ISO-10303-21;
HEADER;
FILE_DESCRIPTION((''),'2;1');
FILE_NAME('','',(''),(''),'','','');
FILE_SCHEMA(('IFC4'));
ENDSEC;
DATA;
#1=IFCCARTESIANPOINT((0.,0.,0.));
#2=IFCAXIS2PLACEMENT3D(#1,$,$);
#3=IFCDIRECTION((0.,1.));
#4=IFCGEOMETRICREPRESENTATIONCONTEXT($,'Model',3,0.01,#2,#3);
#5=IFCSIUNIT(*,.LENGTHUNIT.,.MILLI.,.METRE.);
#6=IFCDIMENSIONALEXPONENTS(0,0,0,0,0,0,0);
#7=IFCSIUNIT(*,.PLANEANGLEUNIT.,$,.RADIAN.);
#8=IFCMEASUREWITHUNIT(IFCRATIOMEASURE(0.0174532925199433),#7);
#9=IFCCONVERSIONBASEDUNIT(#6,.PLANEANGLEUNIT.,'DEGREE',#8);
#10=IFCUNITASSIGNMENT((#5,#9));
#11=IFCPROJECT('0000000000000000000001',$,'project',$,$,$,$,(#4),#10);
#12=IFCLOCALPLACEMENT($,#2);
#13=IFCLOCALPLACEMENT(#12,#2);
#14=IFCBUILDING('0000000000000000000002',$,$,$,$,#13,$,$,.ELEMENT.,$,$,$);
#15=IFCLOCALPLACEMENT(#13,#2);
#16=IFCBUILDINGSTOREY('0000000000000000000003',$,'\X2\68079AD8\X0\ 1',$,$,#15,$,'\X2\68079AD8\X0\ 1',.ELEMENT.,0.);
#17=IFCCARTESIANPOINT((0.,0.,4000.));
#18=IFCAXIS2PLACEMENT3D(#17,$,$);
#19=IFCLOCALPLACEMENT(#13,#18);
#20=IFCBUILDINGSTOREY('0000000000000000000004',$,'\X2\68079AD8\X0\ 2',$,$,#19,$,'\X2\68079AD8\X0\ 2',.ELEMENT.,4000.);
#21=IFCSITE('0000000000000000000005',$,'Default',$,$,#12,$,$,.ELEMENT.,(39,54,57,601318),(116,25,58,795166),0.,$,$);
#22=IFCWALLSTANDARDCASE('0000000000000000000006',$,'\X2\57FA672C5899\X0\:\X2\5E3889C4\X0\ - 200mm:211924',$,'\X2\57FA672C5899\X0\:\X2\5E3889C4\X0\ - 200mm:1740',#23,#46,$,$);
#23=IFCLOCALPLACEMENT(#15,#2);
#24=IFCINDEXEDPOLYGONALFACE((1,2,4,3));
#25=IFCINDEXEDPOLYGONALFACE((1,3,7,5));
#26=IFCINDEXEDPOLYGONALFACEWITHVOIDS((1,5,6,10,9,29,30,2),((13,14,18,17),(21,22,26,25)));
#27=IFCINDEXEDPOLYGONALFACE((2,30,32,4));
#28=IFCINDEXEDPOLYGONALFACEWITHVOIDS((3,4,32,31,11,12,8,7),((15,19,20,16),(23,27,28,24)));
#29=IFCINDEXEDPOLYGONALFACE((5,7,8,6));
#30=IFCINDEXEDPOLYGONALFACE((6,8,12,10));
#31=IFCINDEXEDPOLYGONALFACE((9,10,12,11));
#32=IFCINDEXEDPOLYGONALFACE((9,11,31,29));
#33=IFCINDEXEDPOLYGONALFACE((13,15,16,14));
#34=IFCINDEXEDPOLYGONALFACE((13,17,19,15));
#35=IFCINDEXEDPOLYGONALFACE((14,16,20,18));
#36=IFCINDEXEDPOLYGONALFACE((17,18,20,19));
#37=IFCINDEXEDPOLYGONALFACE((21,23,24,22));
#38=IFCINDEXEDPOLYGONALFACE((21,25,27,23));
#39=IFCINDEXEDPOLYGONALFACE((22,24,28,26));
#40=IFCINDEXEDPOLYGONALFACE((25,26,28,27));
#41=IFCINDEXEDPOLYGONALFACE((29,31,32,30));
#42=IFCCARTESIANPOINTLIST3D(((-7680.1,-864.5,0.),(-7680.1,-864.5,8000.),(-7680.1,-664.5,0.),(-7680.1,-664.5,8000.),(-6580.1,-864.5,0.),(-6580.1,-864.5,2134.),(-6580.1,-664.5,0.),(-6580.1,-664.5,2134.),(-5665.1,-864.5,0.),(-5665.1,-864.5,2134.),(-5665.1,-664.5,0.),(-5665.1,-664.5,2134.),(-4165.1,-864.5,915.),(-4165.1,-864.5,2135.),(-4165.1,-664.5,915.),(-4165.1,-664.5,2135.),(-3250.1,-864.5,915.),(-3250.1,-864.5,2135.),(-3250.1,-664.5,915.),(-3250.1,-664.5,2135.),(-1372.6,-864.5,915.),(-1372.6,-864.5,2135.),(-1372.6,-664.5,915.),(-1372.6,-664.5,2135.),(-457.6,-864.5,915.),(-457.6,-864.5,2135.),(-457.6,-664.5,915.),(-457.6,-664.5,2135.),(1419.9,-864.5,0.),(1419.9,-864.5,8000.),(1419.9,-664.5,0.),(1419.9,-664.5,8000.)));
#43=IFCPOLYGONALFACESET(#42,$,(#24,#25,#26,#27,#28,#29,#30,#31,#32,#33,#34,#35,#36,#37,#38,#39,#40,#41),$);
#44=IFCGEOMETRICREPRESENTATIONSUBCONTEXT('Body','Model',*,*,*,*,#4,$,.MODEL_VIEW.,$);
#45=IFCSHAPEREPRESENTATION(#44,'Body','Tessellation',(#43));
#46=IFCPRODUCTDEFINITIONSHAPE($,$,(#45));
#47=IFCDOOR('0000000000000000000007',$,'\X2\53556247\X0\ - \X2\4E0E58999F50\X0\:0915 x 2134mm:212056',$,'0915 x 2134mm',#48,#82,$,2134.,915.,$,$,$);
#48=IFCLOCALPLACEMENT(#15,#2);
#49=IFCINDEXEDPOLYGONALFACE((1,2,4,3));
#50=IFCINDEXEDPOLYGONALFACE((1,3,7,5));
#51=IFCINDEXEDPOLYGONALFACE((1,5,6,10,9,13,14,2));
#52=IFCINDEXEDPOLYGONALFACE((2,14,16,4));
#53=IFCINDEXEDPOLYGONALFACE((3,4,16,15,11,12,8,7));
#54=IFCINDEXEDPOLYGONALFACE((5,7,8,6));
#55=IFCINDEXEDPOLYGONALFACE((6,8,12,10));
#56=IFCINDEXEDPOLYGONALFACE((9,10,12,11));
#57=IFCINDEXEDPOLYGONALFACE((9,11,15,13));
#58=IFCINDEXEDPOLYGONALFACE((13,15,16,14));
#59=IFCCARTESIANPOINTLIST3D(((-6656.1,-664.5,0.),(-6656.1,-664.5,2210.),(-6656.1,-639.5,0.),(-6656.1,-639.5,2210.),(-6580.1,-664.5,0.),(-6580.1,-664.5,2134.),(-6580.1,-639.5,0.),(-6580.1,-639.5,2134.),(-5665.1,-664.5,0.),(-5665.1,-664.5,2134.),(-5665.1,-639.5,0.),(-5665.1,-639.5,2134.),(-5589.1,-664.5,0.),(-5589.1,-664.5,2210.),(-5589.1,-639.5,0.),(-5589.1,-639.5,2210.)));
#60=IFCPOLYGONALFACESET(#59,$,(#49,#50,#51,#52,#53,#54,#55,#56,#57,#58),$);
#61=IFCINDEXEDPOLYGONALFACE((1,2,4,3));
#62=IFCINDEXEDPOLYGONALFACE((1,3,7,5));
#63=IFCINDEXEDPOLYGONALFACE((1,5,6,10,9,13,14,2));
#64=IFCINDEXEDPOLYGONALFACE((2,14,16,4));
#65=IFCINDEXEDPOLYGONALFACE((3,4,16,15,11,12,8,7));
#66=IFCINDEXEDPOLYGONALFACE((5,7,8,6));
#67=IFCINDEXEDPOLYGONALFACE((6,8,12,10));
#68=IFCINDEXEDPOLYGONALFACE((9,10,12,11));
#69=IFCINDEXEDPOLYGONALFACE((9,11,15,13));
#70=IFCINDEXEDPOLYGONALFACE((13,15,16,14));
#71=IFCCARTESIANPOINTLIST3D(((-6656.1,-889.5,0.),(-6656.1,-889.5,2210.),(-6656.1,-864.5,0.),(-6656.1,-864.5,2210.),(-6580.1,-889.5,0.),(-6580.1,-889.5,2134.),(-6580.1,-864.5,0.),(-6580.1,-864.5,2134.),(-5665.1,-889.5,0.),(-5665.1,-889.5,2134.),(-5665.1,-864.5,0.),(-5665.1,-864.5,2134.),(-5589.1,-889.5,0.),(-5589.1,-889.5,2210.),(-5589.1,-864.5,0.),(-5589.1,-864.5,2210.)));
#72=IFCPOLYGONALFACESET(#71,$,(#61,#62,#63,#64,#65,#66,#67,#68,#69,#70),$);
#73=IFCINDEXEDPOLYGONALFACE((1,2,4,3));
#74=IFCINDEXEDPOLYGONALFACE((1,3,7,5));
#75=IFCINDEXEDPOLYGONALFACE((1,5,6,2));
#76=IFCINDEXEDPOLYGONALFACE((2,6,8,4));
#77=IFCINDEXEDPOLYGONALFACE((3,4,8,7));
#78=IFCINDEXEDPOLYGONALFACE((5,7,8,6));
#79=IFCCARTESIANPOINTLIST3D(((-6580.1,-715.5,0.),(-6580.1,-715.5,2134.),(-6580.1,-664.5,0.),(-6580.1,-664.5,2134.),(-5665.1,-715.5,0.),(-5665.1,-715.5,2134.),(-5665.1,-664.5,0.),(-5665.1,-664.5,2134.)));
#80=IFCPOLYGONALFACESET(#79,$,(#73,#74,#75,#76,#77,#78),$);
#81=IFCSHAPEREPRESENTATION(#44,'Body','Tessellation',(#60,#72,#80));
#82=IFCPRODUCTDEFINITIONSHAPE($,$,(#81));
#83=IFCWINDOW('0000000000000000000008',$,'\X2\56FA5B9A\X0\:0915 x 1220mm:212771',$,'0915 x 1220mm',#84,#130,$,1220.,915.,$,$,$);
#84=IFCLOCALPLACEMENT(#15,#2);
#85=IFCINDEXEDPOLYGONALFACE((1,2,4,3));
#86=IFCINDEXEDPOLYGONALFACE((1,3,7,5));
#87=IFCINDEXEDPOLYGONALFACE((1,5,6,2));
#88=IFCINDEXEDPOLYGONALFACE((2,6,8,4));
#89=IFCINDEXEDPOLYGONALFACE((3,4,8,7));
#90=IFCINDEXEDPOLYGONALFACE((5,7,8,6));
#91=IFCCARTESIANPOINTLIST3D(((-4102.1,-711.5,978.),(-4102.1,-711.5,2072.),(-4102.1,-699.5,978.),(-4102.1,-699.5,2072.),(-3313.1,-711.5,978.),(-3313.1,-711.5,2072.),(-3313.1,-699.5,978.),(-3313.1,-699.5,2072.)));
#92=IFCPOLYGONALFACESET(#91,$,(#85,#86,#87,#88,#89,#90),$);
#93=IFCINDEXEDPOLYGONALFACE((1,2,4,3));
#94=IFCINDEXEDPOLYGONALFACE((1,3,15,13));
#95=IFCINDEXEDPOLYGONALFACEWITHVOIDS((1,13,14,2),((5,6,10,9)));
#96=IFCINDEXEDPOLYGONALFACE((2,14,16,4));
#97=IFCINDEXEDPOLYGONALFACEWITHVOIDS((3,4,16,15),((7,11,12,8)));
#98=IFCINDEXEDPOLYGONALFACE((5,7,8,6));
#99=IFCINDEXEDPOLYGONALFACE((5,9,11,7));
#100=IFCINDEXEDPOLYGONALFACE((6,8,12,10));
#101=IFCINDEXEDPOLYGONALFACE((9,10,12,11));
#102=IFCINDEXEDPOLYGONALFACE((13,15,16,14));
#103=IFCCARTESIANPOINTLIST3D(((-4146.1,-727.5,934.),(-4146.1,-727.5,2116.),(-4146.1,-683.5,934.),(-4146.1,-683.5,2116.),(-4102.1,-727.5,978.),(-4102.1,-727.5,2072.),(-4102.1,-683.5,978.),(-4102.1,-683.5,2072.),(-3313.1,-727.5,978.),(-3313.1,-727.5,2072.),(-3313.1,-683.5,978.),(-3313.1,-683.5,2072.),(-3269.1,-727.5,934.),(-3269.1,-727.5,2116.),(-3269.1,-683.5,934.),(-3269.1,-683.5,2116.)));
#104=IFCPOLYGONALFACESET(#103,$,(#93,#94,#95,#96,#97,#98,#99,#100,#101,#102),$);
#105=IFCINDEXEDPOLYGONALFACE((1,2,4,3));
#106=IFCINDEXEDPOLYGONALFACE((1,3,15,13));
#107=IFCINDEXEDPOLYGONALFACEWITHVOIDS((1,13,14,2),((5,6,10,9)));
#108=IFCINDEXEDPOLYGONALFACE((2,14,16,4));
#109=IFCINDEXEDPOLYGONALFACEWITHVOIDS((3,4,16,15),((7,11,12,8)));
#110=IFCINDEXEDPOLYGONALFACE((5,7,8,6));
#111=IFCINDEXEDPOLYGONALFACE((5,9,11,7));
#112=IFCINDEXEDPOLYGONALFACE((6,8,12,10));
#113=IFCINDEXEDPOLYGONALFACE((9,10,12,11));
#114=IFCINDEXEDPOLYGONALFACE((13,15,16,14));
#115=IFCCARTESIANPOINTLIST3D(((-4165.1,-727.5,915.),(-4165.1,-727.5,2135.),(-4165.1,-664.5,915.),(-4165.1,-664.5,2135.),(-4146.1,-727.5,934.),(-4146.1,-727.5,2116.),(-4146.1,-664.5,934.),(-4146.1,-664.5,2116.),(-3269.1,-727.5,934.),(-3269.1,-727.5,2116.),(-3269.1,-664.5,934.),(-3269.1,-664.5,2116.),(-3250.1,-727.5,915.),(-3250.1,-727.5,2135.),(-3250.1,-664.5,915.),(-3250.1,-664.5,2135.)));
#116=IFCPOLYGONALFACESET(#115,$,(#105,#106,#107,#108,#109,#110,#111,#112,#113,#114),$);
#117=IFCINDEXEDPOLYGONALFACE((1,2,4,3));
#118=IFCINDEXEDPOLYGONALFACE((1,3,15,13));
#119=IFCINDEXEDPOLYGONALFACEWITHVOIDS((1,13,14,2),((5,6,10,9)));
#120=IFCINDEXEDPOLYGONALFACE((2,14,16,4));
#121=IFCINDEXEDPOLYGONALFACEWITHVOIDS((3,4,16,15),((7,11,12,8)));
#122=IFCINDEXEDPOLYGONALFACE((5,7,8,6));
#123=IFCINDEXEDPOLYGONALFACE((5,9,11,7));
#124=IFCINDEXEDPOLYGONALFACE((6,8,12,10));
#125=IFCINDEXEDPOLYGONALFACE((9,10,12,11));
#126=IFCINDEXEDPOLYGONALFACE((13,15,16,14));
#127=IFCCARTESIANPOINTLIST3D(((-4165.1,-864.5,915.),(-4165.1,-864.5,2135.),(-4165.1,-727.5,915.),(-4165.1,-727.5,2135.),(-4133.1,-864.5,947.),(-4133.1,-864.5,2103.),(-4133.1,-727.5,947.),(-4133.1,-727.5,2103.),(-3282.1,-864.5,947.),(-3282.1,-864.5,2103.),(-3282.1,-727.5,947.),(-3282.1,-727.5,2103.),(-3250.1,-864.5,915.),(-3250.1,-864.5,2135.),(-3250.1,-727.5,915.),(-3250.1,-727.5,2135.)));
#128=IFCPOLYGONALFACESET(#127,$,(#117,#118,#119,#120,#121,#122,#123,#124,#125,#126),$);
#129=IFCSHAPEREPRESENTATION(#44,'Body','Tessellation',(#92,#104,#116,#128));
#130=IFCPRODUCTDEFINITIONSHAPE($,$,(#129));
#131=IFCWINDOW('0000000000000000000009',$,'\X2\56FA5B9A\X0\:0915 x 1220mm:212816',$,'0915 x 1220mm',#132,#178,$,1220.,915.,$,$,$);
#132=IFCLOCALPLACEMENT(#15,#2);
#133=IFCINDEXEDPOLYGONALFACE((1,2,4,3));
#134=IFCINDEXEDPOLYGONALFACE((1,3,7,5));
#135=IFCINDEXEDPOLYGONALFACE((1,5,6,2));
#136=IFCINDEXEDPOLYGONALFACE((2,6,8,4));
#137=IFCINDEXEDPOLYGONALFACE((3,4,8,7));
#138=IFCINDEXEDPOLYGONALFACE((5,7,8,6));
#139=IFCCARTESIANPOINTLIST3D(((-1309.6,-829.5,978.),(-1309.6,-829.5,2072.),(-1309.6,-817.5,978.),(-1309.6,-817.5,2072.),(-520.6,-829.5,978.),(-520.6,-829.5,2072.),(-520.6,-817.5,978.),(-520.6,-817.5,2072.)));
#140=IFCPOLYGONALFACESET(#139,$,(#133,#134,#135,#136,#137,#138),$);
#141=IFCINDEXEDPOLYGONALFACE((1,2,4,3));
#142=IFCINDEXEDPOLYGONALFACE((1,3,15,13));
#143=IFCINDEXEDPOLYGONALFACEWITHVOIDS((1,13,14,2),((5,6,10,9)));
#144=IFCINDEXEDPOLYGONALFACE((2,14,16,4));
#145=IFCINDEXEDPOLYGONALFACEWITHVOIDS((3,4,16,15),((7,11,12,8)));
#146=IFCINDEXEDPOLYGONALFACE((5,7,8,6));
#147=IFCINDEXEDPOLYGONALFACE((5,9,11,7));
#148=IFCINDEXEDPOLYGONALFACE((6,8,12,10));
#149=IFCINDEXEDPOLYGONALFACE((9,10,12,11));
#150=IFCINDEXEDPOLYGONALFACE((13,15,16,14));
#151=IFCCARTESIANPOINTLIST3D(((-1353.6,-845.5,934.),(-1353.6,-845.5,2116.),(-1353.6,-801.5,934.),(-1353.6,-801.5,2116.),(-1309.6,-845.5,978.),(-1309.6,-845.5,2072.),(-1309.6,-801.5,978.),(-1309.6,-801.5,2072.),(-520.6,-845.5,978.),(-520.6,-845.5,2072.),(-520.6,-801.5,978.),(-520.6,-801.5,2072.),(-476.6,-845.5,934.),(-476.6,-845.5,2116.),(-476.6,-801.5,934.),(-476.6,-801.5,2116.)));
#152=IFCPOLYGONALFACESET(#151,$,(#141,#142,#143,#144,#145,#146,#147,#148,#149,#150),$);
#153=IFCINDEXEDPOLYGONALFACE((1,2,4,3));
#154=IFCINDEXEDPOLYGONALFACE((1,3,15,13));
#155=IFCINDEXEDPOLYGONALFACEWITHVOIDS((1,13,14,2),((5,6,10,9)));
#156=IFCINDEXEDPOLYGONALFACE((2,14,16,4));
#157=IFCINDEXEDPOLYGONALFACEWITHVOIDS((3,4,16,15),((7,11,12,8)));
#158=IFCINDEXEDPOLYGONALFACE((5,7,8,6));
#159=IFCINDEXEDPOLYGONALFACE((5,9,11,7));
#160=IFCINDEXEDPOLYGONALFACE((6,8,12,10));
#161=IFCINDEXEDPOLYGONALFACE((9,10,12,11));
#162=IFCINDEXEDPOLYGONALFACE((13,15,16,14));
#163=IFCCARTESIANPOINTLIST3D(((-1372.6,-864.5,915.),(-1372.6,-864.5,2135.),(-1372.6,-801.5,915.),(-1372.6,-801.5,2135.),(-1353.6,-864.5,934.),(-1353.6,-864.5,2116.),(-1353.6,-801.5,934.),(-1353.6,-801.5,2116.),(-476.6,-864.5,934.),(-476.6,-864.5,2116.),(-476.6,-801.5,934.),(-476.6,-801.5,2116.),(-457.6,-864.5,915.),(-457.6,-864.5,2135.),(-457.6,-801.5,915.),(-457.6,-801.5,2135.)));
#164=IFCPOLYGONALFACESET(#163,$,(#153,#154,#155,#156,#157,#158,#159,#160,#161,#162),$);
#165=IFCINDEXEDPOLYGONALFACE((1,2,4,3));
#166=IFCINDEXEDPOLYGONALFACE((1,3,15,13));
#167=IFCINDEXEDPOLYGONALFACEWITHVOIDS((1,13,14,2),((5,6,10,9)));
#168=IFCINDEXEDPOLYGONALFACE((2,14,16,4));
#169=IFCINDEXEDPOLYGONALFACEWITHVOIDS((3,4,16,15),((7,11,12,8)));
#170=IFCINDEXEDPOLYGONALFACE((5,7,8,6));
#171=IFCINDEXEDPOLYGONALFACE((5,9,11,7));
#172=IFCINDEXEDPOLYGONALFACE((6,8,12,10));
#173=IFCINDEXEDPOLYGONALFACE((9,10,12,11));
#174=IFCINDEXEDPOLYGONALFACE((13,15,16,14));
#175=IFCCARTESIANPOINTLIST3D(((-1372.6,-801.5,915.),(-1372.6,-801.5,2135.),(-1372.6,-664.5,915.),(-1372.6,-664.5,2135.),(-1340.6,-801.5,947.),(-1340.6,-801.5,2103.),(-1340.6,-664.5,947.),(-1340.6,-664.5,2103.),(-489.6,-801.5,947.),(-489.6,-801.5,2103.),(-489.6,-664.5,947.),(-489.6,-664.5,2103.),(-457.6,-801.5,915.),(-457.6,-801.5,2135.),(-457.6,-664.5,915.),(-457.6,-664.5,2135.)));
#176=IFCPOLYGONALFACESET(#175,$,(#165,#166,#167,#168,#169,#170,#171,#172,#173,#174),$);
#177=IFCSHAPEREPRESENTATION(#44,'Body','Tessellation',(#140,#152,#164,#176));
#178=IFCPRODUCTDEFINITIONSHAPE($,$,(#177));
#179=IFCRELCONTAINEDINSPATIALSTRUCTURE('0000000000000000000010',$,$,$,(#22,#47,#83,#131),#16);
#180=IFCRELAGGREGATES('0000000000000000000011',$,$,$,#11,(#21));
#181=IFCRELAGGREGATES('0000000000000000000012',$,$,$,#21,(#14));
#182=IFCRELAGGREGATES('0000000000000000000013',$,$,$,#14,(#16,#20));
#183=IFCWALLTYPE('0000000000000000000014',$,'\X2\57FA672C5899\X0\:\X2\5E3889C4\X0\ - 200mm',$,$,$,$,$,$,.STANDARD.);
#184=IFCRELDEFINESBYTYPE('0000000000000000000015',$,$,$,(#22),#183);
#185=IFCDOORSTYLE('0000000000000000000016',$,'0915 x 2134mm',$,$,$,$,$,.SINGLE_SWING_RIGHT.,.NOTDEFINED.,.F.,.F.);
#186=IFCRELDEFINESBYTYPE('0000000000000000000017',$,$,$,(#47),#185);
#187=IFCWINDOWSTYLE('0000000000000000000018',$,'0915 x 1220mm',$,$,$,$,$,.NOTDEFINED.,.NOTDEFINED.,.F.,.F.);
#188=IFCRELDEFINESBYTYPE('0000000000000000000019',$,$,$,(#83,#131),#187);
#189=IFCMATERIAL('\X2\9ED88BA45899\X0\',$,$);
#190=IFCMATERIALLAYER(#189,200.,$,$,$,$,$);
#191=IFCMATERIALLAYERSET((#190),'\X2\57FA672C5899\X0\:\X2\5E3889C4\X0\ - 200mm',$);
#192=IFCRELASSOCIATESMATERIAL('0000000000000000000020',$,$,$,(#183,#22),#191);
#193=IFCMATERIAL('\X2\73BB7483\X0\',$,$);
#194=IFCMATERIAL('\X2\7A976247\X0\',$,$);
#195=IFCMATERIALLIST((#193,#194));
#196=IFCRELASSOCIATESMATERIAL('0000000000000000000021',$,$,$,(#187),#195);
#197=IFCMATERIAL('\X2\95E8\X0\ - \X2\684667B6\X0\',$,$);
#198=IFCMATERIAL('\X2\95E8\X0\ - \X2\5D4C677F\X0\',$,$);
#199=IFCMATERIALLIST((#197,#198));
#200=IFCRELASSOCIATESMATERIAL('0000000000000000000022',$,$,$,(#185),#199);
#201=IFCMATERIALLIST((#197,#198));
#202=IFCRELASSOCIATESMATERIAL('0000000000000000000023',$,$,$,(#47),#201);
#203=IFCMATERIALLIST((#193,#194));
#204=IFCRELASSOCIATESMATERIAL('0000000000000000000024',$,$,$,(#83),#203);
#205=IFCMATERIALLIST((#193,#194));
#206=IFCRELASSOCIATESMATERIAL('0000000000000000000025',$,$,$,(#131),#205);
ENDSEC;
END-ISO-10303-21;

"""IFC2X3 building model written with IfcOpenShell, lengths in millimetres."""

from ifc_helpers import new_model, entity, si_unit, converted_unit, direction, frame, frame_2d, origin, place, context, subcontext, project, spatial, polyline, rectangle, outline, extrude, source, transform, mapped, material, material_list, layer, layer_set, layer_usage, type_object, type_shapes, element, fill, save


model = new_model("IFC2X3")

# Units and contexts
model_context = context("Model", 3, precision=0.01, world=origin(), true_north=direction((0.0, 1.0)))
body_context = subcontext(model_context, "Body", "Model", "MODEL_VIEW")
ifc_project = project(units=[si_unit("LENGTHUNIT", "METRE", prefix="MILLI"), converted_unit("PLANEANGLEUNIT", "DEGREE", entity("IfcRatioMeasure", 0.0174532925199433), si_unit("PLANEANGLEUNIT", "RADIAN"), dimensions=[0, 0, 0, 0, 0, 0, 0])], contexts=[model_context])

# Site, building, storey
site_placement = place(None, origin())
site = spatial("IfcSite", under=ifc_project, at=site_placement, Name="Default", CompositionType="ELEMENT", RefLatitude=(39, 54, 57, 601318), RefLongitude=(116, 25, 58, 795166), RefElevation=0.0)
building_placement = place(site_placement, origin())
building = spatial("IfcBuilding", under=site, at=building_placement, CompositionType="ELEMENT")
storey_1_placement = place(building_placement, origin())
storey_1 = spatial("IfcBuildingStorey", under=building, at=storey_1_placement, Name="标高 1", LongName="标高 1", CompositionType="ELEMENT", Elevation=0.0)

# Shared definitions
ifc_material_1 = material(Name="默认墙")
ifc_layer_1 = layer(ifc_material_1, 200.0)
ifc_layer_set_1 = layer_set([ifc_layer_1], Name="基本墙:常规 - 200mm")
wall_type_1 = type_object("IfcWallType", Name="基本墙:常规 - 200mm", PredefinedType="STANDARD", material=ifc_layer_set_1)
ifc_material_2 = material(Name="玻璃")
ifc_material_3 = material(Name="窗扇")
ifc_material_list_1 = material_list([ifc_material_2, ifc_material_3])
window_style = type_object("IfcWindowStyle", Name="0915 x 1220mm", ConstructionType="NOTDEFINED", OperationType="NOTDEFINED", ParameterTakesPrecedence=False, Sizeable=False, material=ifc_material_list_1)
shared_shape_1 = source(origin(), body_context, "Body", "SweptSolid", [
    extrude(rectangle(XDim=12.0, YDim=789.0, at=frame_2d((0.0, 0.0), x_axis=(1.0, 0.0))), frame((457.5, 159.0, 63.0), z_axis=(0.0, 0.0, 1.0), x_axis=(0.0, -1.0, 0.0)), (0.0, 0.0, 1.0), 1094.0),
    extrude(outline(polyline([(-438.5, -591.0), (438.5, -591.0), (438.5, 591.0), (-438.5, 591.0), (-438.5, -591.0)]), holes=[polyline([(-394.5, -547.0), (-394.5, 547.0), (394.5, 547.0), (394.5, -547.0), (-394.5, -547.0)])]), frame((457.5, 137.0, 610.0), z_axis=(0.0, 1.0, 0.0), x_axis=(1.0, 0.0, 0.0)), (0.0, 0.0, 1.0), 44.0),
    extrude(outline(polyline([(-457.5, -610.0), (457.5, -610.0), (457.5, 610.0), (-457.5, 610.0), (-457.5, -610.0)]), holes=[polyline([(-438.5, -591.0), (-438.5, 591.0), (438.5, 591.0), (438.5, -591.0), (-438.5, -591.0)])]), frame((457.5, 137.0, 610.0), z_axis=(0.0, 1.0, 0.0), x_axis=(1.0, 0.0, 0.0)), (0.0, 0.0, 1.0), 63.0),
    extrude(outline(polyline([(-457.5, -610.0), (457.5, -610.0), (457.5, 610.0), (-457.5, 610.0), (-457.5, -610.0)]), holes=[polyline([(-425.5, -578.0), (-425.5, 578.0), (425.5, 578.0), (425.5, -578.0), (-425.5, -578.0)])]), frame((457.5, 0.0, 610.0), z_axis=(0.0, 1.0, 0.0), x_axis=(1.0, 0.0, 0.0)), (0.0, 0.0, 1.0), 137.0),
])
type_shapes(window_style, [shared_shape_1])

# Wall, openings, door, windows
ifc_layer_usage_1 = layer_usage(ifc_layer_set_1, "AXIS2", "NEGATIVE", 100.0)
wall_1_placement = place(storey_1_placement, frame((1419.9, -764.5, 0.0), z_axis=(0.0, 0.0, 1.0), x_axis=(-1.0, 0.0, 0.0)))
wall_1 = element("IfcWallStandardCase", 1, at=wall_1_placement, inside=storey_1, type_object=wall_type_1, material=ifc_layer_usage_1, Name="基本墙:常规 - 200mm:211924", ObjectType="基本墙:常规 - 200mm:1740", context=body_context, shape_type="SweptSolid", body=[
    extrude(rectangle(XDim=9100.0, YDim=200.0, at=frame_2d((4550.0, 0.0), x_axis=(-1.0, 0.0))), origin(), (0.0, 0.0, 1.0), 8000.0),
])
opening_1_placement = place(wall_1_placement, frame((8000.0, 100.0, 0.0)))
opening_1 = element("IfcOpeningElement", 2, at=opening_1_placement, cuts=wall_1, ObjectType="Opening", context=body_context, shape_type="SweptSolid", body=[
    extrude(rectangle(XDim=915.0, YDim=2134.0, at=frame_2d((1067.0, 457.5), x_axis=(0.0, 1.0))), frame((0.0, 0.0, 0.0), z_axis=(0.0, -1.0, 0.0), x_axis=(0.0, 0.0, 1.0)), (0.0, 0.0, 1.0), 200.0),
])
opening_2_placement = place(wall_1_placement, frame((5585.0, 100.0, 915.0)))
opening_2 = element("IfcOpeningElement", 3, at=opening_2_placement, cuts=wall_1, ObjectType="Opening", context=body_context, shape_type="SweptSolid", body=[
    extrude(rectangle(XDim=1220.0, YDim=915.0, at=frame_2d((610.0, 457.5), x_axis=(1.0, 0.0))), frame((0.0, 0.0, 0.0), z_axis=(0.0, -1.0, 0.0), x_axis=(0.0, 0.0, 1.0)), (0.0, 0.0, 1.0), 200.0),
])
opening_3_placement = place(wall_1_placement, frame((1877.5, -100.0, 915.0)))
opening_3 = element("IfcOpeningElement", 4, at=opening_3_placement, cuts=wall_1, ObjectType="Opening", context=body_context, shape_type="SweptSolid", body=[
    extrude(rectangle(XDim=1220.0, YDim=915.0, at=frame_2d((610.0, 457.5), x_axis=(1.0, 0.0))), frame((0.0, 0.0, 0.0), z_axis=(0.0, 1.0, 0.0), x_axis=(0.0, 0.0, 1.0)), (0.0, 0.0, 1.0), 200.0),
])
ifc_material_4 = material(Name="门 - 框架")
ifc_material_5 = material(Name="门 - 嵌板")
ifc_material_list_2 = material_list([ifc_material_4, ifc_material_5])
ifc_material_list_3 = material_list([ifc_material_4, ifc_material_5])
door_style = type_object("IfcDoorStyle", Name="0915 x 2134mm", ConstructionType="NOTDEFINED", OperationType="SINGLE_SWING_RIGHT", ParameterTakesPrecedence=False, Sizeable=False, material=ifc_material_list_3)
shared_shape_2 = source(origin(), body_context, "Body", "SweptSolid", [
    extrude(outline(polyline([(-533.5, -1124.0), (533.5, -1124.0), (533.5, 1086.0), (457.5, 1086.0), (457.5, -1048.0), (-457.5, -1048.0), (-457.5, 1086.0), (-533.5, 1086.0), (-533.5, -1124.0)])), frame((457.5, 200.0, 1086.0), z_axis=(0.0, 1.0, 0.0), x_axis=(1.0, 0.0, 0.0)), (0.0, 0.0, 1.0), 25.0),
    extrude(outline(polyline([(-1124.0, -533.5), (1086.0, -533.5), (1086.0, -457.5), (-1048.0, -457.5), (-1048.0, 457.5), (1086.0, 457.5), (1086.0, 533.5), (-1124.0, 533.5), (-1124.0, -533.5)])), frame((457.5, -25.0, 1086.0), z_axis=(0.0, 1.0, 0.0), x_axis=(0.0, 0.0, -1.0)), (0.0, 0.0, 1.0), 25.0),
    extrude(rectangle(XDim=51.0, YDim=915.0, at=frame_2d((0.0, 0.0), x_axis=(1.0, 0.0))), frame((457.5, 174.5, 0.0), z_axis=(0.0, 0.0, 1.0), x_axis=(0.0, 1.0, 0.0)), (0.0, 0.0, 1.0), 2134.0),
])
type_shapes(door_style, [shared_shape_2])
door_placement = place(opening_1_placement, frame((0.0, 0.0, 0.0), z_axis=(0.0, 0.0, 1.0), x_axis=(-1.0, 0.0, 0.0)))
door = element("IfcDoor", 5, at=door_placement, inside=storey_1, type_object=door_style, material=ifc_material_list_2, Name="单扇 - 与墙齐:0915 x 2134mm:212056", ObjectType="0915 x 2134mm", OverallHeight=2134.0, OverallWidth=915.0, context=body_context, shape_type="MappedRepresentation", body=[
    mapped(shared_shape_2, transform((0.0, 0.0, 0.0), scale=1.0)),
])
fill(opening_1, door)
ifc_material_list_4 = material_list([ifc_material_2, ifc_material_3])
window_1_placement = place(opening_2_placement, frame((0.0, 0.0, 0.0), z_axis=(0.0, 0.0, 1.0), x_axis=(-1.0, 0.0, 0.0)))
window_1 = element("IfcWindow", 6, at=window_1_placement, inside=storey_1, type_object=window_style, material=ifc_material_list_4, Name="固定:0915 x 1220mm:212771", ObjectType="0915 x 1220mm", OverallHeight=1220.0, OverallWidth=915.0, context=body_context, shape_type="MappedRepresentation", body=[
    mapped(shared_shape_1, transform((0.0, 0.0, 0.0), scale=1.0)),
])
fill(opening_2, window_1)
ifc_material_list_5 = material_list([ifc_material_2, ifc_material_3])
window_2_placement = place(opening_3_placement, origin())
window_2 = element("IfcWindow", 7, at=window_2_placement, inside=storey_1, type_object=window_style, material=ifc_material_list_5, Name="固定:0915 x 1220mm:212816", ObjectType="0915 x 1220mm", OverallHeight=1220.0, OverallWidth=915.0, context=body_context, shape_type="MappedRepresentation", body=[
    mapped(shared_shape_1, transform((0.0, 0.0, 0.0), scale=1.0)),
])
fill(opening_3, window_2)

# Shared definitions
storey_2_placement = place(building_placement, frame((0.0, 0.0, 4000.0)))
storey_2 = spatial("IfcBuildingStorey", under=building, at=storey_2_placement, Name="标高 2", LongName="标高 2", CompositionType="ELEMENT", Elevation=4000.0)

save(model, "model.ifc")
